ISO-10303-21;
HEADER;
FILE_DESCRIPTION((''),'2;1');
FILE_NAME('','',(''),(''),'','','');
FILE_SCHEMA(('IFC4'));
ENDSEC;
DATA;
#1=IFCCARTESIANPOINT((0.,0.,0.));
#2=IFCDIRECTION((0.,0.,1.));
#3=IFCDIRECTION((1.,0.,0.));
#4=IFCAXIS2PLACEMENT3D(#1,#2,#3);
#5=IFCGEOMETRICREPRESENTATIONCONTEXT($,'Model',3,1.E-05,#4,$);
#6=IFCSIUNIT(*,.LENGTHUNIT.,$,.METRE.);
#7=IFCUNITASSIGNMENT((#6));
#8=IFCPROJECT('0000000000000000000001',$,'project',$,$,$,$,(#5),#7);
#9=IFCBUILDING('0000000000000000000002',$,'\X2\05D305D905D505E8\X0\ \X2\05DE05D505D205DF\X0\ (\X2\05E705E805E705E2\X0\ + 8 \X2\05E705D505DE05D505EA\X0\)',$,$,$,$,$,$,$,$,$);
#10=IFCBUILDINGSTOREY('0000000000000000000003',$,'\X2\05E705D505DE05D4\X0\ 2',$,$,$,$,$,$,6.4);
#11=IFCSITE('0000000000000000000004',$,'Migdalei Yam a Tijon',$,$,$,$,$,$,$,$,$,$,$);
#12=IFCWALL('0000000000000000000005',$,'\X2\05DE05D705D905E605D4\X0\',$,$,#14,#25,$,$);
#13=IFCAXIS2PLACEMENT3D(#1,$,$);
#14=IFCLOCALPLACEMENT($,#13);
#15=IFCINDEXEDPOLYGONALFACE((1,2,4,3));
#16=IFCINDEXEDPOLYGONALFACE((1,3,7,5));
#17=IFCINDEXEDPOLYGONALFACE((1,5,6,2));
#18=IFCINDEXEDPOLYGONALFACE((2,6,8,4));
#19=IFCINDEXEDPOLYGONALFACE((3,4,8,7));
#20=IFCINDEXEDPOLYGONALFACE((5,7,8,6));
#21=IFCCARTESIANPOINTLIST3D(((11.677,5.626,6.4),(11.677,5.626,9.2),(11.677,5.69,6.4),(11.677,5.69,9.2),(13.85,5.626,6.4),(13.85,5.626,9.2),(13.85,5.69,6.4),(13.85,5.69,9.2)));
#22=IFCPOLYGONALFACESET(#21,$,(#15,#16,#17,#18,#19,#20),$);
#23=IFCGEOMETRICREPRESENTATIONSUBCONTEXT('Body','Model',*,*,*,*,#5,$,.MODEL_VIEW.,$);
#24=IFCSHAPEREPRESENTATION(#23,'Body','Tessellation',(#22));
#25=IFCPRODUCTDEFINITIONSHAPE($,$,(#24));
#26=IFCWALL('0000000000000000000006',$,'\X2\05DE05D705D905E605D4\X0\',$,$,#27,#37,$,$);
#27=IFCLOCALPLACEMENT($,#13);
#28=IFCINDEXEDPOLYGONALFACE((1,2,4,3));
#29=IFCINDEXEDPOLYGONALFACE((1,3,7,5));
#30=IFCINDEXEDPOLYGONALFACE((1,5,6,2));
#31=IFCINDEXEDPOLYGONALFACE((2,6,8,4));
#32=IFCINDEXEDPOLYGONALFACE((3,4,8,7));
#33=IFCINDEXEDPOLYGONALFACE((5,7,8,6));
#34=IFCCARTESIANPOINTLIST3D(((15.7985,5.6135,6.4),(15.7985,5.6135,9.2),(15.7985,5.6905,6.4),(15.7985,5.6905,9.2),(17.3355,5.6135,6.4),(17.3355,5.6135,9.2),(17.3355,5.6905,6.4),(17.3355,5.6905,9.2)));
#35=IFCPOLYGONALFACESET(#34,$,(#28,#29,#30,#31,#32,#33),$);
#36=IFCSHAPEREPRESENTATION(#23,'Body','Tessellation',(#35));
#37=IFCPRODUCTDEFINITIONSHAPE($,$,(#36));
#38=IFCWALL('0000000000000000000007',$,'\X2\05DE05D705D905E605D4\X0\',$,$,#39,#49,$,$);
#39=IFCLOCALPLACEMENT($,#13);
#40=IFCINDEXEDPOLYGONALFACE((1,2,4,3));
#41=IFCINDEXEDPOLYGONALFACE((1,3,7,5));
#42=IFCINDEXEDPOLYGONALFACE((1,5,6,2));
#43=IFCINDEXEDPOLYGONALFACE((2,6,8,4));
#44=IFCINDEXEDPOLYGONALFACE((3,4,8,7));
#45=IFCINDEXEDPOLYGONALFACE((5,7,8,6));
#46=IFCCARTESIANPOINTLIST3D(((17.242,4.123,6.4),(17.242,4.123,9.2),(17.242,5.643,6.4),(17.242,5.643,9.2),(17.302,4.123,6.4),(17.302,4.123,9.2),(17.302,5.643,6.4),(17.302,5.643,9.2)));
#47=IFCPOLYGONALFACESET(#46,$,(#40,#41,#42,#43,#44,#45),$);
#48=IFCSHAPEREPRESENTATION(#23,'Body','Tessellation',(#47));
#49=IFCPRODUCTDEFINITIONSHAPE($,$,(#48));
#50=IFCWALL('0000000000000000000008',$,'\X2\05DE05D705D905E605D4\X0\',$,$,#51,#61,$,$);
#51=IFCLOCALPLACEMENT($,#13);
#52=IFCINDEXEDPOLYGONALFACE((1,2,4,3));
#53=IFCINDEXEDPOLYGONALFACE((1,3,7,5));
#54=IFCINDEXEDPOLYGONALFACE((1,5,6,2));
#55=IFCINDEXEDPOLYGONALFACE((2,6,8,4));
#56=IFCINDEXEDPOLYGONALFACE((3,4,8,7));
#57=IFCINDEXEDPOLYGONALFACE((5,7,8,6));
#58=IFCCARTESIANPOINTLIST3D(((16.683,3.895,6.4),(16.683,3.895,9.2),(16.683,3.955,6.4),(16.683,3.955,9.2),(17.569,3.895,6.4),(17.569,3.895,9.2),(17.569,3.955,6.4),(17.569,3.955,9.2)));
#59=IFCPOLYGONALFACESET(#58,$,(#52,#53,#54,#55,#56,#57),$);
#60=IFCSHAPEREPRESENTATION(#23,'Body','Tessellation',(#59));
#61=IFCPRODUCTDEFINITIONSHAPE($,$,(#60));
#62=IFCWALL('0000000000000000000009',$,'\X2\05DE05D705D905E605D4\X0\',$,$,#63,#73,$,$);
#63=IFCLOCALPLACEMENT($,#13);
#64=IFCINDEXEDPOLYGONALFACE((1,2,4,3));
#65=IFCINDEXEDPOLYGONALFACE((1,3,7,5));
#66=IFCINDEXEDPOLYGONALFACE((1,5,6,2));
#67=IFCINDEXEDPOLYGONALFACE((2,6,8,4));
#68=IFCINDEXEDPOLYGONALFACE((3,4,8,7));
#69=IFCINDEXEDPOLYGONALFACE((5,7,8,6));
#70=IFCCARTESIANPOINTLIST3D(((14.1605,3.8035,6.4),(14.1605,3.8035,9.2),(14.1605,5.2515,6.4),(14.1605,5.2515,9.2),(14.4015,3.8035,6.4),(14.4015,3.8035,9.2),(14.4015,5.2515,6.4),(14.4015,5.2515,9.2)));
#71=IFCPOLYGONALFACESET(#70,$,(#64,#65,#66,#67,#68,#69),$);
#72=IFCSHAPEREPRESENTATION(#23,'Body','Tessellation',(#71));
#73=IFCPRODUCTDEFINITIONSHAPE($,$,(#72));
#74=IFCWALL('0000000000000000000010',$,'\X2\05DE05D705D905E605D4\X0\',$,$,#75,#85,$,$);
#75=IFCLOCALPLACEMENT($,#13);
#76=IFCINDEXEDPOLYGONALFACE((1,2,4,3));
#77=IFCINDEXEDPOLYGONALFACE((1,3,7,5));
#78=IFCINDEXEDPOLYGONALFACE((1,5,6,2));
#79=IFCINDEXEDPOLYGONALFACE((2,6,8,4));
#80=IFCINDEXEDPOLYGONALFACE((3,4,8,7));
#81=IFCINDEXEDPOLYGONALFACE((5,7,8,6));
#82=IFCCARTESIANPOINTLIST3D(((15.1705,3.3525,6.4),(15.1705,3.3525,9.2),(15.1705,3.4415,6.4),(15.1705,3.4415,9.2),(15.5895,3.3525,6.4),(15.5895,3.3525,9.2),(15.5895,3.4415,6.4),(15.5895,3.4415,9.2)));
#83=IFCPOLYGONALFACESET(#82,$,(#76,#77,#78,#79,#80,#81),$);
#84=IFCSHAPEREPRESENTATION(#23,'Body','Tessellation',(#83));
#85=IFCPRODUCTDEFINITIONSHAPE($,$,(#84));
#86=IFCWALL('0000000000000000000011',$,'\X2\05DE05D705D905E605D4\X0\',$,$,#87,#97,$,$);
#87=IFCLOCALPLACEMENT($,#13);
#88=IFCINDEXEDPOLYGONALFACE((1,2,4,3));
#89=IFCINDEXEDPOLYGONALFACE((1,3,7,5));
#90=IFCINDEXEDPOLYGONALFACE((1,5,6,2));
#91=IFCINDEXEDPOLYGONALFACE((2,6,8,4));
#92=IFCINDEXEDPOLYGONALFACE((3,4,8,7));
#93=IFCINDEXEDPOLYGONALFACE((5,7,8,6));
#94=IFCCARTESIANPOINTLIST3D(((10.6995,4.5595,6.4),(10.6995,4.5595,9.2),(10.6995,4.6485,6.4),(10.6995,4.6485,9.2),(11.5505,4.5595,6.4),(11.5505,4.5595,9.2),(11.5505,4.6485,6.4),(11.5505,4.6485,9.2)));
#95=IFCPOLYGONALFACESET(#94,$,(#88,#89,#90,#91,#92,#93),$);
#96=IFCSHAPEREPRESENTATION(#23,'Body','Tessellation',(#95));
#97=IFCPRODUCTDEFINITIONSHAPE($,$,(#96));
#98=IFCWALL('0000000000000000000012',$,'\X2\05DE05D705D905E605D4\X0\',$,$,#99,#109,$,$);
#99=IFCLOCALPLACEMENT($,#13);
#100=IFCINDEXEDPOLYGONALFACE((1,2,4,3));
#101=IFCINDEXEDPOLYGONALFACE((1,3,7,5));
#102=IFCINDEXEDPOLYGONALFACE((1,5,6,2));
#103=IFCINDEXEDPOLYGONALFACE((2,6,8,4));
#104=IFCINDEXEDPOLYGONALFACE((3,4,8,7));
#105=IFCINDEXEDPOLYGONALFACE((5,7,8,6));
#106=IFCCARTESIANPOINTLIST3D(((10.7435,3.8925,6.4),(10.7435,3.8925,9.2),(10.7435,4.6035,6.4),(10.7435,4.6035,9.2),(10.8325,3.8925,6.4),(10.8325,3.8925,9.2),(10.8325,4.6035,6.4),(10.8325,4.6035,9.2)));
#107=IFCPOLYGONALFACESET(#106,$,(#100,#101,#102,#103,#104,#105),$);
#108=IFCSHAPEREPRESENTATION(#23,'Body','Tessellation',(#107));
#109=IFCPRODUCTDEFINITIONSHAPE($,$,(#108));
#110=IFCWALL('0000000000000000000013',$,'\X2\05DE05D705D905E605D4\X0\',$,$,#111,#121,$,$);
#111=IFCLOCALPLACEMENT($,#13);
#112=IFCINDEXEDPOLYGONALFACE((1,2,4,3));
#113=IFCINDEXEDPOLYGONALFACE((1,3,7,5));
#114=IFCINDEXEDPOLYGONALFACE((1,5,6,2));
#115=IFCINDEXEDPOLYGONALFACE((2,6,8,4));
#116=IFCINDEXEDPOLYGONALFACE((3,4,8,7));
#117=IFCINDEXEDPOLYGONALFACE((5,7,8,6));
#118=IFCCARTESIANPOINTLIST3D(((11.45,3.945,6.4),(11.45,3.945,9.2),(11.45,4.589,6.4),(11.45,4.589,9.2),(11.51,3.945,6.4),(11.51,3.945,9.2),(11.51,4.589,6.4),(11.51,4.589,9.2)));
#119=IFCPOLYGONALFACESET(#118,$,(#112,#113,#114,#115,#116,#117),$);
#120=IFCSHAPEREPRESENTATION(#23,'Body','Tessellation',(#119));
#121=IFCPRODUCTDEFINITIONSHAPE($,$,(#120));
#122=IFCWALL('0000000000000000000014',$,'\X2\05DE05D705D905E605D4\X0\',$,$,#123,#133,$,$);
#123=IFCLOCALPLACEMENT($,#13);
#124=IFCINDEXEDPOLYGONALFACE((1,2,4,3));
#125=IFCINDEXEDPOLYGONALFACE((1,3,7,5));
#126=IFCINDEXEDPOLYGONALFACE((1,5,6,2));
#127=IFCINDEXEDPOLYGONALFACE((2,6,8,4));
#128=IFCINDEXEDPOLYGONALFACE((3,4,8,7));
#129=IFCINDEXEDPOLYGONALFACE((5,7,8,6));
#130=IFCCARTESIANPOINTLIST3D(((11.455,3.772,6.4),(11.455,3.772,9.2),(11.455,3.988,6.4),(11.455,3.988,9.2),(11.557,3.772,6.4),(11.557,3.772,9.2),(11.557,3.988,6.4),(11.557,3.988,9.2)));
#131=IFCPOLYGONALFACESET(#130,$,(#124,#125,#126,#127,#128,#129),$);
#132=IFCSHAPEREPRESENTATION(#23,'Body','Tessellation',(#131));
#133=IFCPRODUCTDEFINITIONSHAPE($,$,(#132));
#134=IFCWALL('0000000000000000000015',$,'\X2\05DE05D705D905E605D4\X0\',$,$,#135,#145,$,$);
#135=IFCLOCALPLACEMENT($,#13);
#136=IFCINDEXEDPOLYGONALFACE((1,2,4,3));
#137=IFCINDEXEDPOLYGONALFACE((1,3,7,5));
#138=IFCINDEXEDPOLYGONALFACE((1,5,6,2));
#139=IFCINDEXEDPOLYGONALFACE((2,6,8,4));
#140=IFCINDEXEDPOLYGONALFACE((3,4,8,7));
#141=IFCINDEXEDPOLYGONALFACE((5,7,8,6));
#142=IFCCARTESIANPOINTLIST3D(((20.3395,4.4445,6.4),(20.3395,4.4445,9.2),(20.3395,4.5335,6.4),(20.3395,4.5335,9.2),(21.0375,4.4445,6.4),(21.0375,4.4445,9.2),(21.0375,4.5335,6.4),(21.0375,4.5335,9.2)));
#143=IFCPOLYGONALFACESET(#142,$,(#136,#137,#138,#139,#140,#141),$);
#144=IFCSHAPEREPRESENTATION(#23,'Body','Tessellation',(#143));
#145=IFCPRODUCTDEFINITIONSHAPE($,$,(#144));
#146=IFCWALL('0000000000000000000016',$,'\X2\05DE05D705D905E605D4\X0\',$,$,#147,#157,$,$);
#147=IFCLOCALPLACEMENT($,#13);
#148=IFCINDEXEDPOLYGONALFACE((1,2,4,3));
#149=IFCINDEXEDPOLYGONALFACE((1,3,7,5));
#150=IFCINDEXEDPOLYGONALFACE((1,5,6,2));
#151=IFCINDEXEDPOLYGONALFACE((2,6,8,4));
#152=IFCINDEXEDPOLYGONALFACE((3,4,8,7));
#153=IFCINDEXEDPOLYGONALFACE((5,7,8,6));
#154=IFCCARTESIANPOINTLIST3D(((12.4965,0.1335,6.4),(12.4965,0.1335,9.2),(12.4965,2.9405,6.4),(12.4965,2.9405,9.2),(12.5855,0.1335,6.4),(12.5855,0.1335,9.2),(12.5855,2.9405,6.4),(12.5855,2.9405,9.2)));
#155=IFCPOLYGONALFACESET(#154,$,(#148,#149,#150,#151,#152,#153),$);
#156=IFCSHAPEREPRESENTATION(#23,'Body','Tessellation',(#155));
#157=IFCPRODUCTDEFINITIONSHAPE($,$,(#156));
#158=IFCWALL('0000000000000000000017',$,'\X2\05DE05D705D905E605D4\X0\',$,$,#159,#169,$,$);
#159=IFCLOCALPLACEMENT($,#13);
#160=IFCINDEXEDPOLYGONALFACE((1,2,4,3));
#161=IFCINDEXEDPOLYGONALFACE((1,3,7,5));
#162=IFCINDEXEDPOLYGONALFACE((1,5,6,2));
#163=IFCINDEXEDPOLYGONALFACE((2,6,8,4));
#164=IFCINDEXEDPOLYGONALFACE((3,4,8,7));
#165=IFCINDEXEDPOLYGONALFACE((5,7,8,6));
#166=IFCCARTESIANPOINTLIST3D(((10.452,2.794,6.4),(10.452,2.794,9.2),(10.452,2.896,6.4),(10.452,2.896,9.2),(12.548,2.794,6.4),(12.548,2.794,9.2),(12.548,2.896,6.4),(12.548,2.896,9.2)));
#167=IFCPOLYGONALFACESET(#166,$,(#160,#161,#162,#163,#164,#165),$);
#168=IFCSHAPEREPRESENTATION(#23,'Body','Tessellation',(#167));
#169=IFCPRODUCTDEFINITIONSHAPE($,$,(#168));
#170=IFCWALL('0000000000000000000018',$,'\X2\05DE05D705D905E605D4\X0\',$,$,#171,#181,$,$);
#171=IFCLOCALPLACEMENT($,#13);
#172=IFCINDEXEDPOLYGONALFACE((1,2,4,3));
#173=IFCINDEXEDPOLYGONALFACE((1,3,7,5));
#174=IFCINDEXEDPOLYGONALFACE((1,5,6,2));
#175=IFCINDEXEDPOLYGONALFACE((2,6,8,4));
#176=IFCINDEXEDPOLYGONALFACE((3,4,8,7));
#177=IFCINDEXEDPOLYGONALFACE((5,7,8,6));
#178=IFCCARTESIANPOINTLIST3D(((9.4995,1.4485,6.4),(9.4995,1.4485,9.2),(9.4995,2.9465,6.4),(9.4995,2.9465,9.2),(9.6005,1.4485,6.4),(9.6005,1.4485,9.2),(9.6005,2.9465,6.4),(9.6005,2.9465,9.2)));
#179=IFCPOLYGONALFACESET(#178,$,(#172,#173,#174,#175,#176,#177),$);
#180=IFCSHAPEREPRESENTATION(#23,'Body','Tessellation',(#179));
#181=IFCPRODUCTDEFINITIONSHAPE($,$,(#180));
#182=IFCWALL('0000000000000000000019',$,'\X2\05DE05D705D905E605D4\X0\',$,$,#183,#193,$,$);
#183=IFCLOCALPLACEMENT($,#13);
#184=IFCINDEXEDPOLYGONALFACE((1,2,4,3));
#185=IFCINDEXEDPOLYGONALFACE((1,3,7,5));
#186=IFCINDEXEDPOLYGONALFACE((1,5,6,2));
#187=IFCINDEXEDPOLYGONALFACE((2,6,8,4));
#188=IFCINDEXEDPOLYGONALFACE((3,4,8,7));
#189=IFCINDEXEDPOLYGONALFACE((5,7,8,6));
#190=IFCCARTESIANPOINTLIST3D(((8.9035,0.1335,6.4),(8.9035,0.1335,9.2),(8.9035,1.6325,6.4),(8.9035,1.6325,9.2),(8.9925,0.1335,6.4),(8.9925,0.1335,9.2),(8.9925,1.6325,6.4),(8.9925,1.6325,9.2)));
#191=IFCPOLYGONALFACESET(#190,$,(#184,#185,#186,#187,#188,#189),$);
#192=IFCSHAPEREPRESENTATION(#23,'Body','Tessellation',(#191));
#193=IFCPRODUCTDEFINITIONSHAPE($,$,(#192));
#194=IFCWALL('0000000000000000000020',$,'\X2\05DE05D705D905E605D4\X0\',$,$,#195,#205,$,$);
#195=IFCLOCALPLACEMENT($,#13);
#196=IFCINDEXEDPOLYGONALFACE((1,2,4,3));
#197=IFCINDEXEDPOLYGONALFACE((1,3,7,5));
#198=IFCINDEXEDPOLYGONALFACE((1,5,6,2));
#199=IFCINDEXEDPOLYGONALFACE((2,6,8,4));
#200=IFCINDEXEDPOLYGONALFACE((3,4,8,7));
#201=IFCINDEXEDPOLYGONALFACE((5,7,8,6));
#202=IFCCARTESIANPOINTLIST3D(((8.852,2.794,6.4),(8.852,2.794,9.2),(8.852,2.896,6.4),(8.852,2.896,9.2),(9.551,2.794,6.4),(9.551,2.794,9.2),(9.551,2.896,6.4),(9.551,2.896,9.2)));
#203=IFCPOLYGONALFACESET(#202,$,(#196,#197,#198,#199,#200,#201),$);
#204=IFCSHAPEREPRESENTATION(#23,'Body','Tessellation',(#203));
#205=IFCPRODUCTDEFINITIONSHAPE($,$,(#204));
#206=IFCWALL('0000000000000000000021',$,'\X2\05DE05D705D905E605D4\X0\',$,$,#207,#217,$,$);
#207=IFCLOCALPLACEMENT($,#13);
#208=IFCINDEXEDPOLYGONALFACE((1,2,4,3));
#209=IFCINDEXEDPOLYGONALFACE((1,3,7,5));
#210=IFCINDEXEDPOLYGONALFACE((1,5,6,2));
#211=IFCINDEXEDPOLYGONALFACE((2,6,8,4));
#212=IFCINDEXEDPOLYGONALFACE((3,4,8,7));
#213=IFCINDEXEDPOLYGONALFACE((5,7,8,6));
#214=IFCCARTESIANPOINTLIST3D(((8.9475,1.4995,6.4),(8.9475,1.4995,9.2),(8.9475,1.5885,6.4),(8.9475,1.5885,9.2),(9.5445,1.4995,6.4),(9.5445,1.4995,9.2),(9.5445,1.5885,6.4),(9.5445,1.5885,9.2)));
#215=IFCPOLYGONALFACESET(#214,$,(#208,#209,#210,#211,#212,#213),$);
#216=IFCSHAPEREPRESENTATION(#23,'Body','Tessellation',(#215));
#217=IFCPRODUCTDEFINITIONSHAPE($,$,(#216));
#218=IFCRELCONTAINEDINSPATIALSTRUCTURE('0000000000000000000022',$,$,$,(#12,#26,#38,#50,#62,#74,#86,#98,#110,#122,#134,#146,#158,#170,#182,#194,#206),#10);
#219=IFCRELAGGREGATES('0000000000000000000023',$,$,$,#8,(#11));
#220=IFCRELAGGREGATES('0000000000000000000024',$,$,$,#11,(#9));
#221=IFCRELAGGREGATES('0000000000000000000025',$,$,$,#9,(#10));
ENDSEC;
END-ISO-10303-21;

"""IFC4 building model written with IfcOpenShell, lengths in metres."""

from ifc_helpers import new_model, si_unit, frame, origin_with_axes, context, subcontext, project, spatial, line, indexed_curve, outline, extrude, element, save


model = new_model("IFC4")

# Units and contexts
model_context = context("Model", 3, precision=1e-05, world=origin_with_axes())
body_context = subcontext(model_context, "Body", "Model", "MODEL_VIEW")
ifc_project = project(units=[si_unit("LENGTHUNIT", "METRE")], contexts=[model_context])

# Site, building, storey
site = spatial("IfcSite", under=ifc_project, Name="Migdalei Yam a Tijon")
building = spatial("IfcBuilding", under=site, Name="דיור מוגן (קרקע + 8 קומות)")
storey = spatial("IfcBuildingStorey", under=building, Name="קומה 2", Elevation=6.4)

# Walls
element("IfcWall", 1, inside=storey, Name="מחיצה", context=body_context, shape_type="SweptSolid", body=[
    extrude(outline(indexed_curve([(0.0, 0.0), (2.173, 0.0), (2.173, 0.064), (0.0, 0.064)], segments=[line(1, 2, 3, 4, 1)])), frame((11.677, 5.626, 6.4), z_axis=(0.0, 0.0, 1.0), x_axis=(1.0, 0.0, 0.0)), (0.0, 0.0, 1.0), 2.8),
])
element("IfcWall", 2, inside=storey, Name="מחיצה", context=body_context, shape_type="SweptSolid", body=[
    extrude(outline(indexed_curve([(0.0, 0.0), (1.537, 0.0), (1.537, 0.077), (0.0, 0.077)], segments=[line(1, 2, 3, 4, 1)])), frame((15.7985, 5.6135, 6.4), z_axis=(0.0, 0.0, 1.0), x_axis=(1.0, 0.0, 0.0)), (0.0, 0.0, 1.0), 2.8),
])
element("IfcWall", 3, inside=storey, Name="מחיצה", context=body_context, shape_type="SweptSolid", body=[
    extrude(outline(indexed_curve([(0.0, 0.0), (0.06, 0.0), (0.06, 1.52), (0.0, 1.52)], segments=[line(1, 2, 3, 4, 1)])), frame((17.242, 4.123, 6.4), z_axis=(0.0, 0.0, 1.0), x_axis=(1.0, 0.0, 0.0)), (0.0, 0.0, 1.0), 2.8),
])
element("IfcWall", 4, inside=storey, Name="מחיצה", context=body_context, shape_type="SweptSolid", body=[
    extrude(outline(indexed_curve([(0.0, 0.0), (0.886, 0.0), (0.886, 0.06), (0.0, 0.06)], segments=[line(1, 2, 3, 4, 1)])), frame((16.683, 3.895, 6.4), z_axis=(0.0, 0.0, 1.0), x_axis=(1.0, 0.0, 0.0)), (0.0, 0.0, 1.0), 2.8),
])
element("IfcWall", 5, inside=storey, Name="מחיצה", context=body_context, shape_type="SweptSolid", body=[
    extrude(outline(indexed_curve([(0.0, 0.0), (0.241, 0.0), (0.241, 1.448), (0.0, 1.448)], segments=[line(1, 2, 3, 4, 1)])), frame((14.1605, 3.8035, 6.4), z_axis=(0.0, 0.0, 1.0), x_axis=(1.0, 0.0, 0.0)), (0.0, 0.0, 1.0), 2.8),
])
element("IfcWall", 6, inside=storey, Name="מחיצה", context=body_context, shape_type="SweptSolid", body=[
    extrude(outline(indexed_curve([(0.0, 0.0), (0.419, 0.0), (0.419, 0.089), (0.0, 0.089)], segments=[line(1, 2, 3, 4, 1)])), frame((15.1705, 3.3525, 6.4), z_axis=(0.0, 0.0, 1.0), x_axis=(1.0, 0.0, 0.0)), (0.0, 0.0, 1.0), 2.8),
])
element("IfcWall", 7, inside=storey, Name="מחיצה", context=body_context, shape_type="SweptSolid", body=[
    extrude(outline(indexed_curve([(0.0, 0.0), (0.851, 0.0), (0.851, 0.089), (0.0, 0.089)], segments=[line(1, 2, 3, 4, 1)])), frame((10.6995, 4.5595, 6.4), z_axis=(0.0, 0.0, 1.0), x_axis=(1.0, 0.0, 0.0)), (0.0, 0.0, 1.0), 2.8),
])
element("IfcWall", 8, inside=storey, Name="מחיצה", context=body_context, shape_type="SweptSolid", body=[
    extrude(outline(indexed_curve([(0.0, 0.0), (0.089, 0.0), (0.089, 0.711), (0.0, 0.711)], segments=[line(1, 2, 3, 4, 1)])), frame((10.7435, 3.8925, 6.4), z_axis=(0.0, 0.0, 1.0), x_axis=(1.0, 0.0, 0.0)), (0.0, 0.0, 1.0), 2.8),
])
element("IfcWall", 9, inside=storey, Name="מחיצה", context=body_context, shape_type="SweptSolid", body=[
    extrude(outline(indexed_curve([(0.0, 0.0), (0.06, 0.0), (0.06, 0.644), (0.0, 0.644)], segments=[line(1, 2, 3, 4, 1)])), frame((11.45, 3.945, 6.4), z_axis=(0.0, 0.0, 1.0), x_axis=(1.0, 0.0, 0.0)), (0.0, 0.0, 1.0), 2.8),
])
element("IfcWall", 10, inside=storey, Name="מחיצה", context=body_context, shape_type="SweptSolid", body=[
    extrude(outline(indexed_curve([(0.0, 0.0), (0.102, 0.0), (0.102, 0.216), (0.0, 0.216)], segments=[line(1, 2, 3, 4, 1)])), frame((11.455, 3.772, 6.4), z_axis=(0.0, 0.0, 1.0), x_axis=(1.0, 0.0, 0.0)), (0.0, 0.0, 1.0), 2.8),
])
element("IfcWall", 11, inside=storey, Name="מחיצה", context=body_context, shape_type="SweptSolid", body=[
    extrude(outline(indexed_curve([(0.0, 0.0), (0.698, 0.0), (0.698, 0.089), (0.0, 0.089)], segments=[line(1, 2, 3, 4, 1)])), frame((20.3395, 4.4445, 6.4), z_axis=(0.0, 0.0, 1.0), x_axis=(1.0, 0.0, 0.0)), (0.0, 0.0, 1.0), 2.8),
])
element("IfcWall", 12, inside=storey, Name="מחיצה", context=body_context, shape_type="SweptSolid", body=[
    extrude(outline(indexed_curve([(0.0, 0.0), (0.089, 0.0), (0.089, 2.807), (0.0, 2.807)], segments=[line(1, 2, 3, 4, 1)])), frame((12.4965, 0.1335, 6.4), z_axis=(0.0, 0.0, 1.0), x_axis=(1.0, 0.0, 0.0)), (0.0, 0.0, 1.0), 2.8),
])
element("IfcWall", 13, inside=storey, Name="מחיצה", context=body_context, shape_type="SweptSolid", body=[
    extrude(outline(indexed_curve([(0.0, 0.0), (2.096, 0.0), (2.096, 0.102), (0.0, 0.102)], segments=[line(1, 2, 3, 4, 1)])), frame((10.452, 2.794, 6.4), z_axis=(0.0, 0.0, 1.0), x_axis=(1.0, 0.0, 0.0)), (0.0, 0.0, 1.0), 2.8),
])
element("IfcWall", 14, inside=storey, Name="מחיצה", context=body_context, shape_type="SweptSolid", body=[
    extrude(outline(indexed_curve([(0.0, 0.0), (0.101, 0.0), (0.101, 1.498), (0.0, 1.498)], segments=[line(1, 2, 3, 4, 1)])), frame((9.4995, 1.4485, 6.4), z_axis=(0.0, 0.0, 1.0), x_axis=(1.0, 0.0, 0.0)), (0.0, 0.0, 1.0), 2.8),
])
element("IfcWall", 15, inside=storey, Name="מחיצה", context=body_context, shape_type="SweptSolid", body=[
    extrude(outline(indexed_curve([(0.0, 0.0), (0.089, 0.0), (0.089, 1.499), (0.0, 1.499)], segments=[line(1, 2, 3, 4, 1)])), frame((8.9035, 0.1335, 6.4), z_axis=(0.0, 0.0, 1.0), x_axis=(1.0, 0.0, 0.0)), (0.0, 0.0, 1.0), 2.8),
])
element("IfcWall", 16, inside=storey, Name="מחיצה", context=body_context, shape_type="SweptSolid", body=[
    extrude(outline(indexed_curve([(0.0, 0.0), (0.699, 0.0), (0.699, 0.102), (0.0, 0.102)], segments=[line(1, 2, 3, 4, 1)])), frame((8.852, 2.794, 6.4), z_axis=(0.0, 0.0, 1.0), x_axis=(1.0, 0.0, 0.0)), (0.0, 0.0, 1.0), 2.8),
])
element("IfcWall", 17, inside=storey, Name="מחיצה", context=body_context, shape_type="SweptSolid", body=[
    extrude(outline(indexed_curve([(0.0, 0.0), (0.597, 0.0), (0.597, 0.089), (0.0, 0.089)], segments=[line(1, 2, 3, 4, 1)])), frame((8.9475, 1.4995, 6.4), z_axis=(0.0, 0.0, 1.0), x_axis=(1.0, 0.0, 0.0)), (0.0, 0.0, 1.0), 2.8),
])

save(model, "model.ifc")
